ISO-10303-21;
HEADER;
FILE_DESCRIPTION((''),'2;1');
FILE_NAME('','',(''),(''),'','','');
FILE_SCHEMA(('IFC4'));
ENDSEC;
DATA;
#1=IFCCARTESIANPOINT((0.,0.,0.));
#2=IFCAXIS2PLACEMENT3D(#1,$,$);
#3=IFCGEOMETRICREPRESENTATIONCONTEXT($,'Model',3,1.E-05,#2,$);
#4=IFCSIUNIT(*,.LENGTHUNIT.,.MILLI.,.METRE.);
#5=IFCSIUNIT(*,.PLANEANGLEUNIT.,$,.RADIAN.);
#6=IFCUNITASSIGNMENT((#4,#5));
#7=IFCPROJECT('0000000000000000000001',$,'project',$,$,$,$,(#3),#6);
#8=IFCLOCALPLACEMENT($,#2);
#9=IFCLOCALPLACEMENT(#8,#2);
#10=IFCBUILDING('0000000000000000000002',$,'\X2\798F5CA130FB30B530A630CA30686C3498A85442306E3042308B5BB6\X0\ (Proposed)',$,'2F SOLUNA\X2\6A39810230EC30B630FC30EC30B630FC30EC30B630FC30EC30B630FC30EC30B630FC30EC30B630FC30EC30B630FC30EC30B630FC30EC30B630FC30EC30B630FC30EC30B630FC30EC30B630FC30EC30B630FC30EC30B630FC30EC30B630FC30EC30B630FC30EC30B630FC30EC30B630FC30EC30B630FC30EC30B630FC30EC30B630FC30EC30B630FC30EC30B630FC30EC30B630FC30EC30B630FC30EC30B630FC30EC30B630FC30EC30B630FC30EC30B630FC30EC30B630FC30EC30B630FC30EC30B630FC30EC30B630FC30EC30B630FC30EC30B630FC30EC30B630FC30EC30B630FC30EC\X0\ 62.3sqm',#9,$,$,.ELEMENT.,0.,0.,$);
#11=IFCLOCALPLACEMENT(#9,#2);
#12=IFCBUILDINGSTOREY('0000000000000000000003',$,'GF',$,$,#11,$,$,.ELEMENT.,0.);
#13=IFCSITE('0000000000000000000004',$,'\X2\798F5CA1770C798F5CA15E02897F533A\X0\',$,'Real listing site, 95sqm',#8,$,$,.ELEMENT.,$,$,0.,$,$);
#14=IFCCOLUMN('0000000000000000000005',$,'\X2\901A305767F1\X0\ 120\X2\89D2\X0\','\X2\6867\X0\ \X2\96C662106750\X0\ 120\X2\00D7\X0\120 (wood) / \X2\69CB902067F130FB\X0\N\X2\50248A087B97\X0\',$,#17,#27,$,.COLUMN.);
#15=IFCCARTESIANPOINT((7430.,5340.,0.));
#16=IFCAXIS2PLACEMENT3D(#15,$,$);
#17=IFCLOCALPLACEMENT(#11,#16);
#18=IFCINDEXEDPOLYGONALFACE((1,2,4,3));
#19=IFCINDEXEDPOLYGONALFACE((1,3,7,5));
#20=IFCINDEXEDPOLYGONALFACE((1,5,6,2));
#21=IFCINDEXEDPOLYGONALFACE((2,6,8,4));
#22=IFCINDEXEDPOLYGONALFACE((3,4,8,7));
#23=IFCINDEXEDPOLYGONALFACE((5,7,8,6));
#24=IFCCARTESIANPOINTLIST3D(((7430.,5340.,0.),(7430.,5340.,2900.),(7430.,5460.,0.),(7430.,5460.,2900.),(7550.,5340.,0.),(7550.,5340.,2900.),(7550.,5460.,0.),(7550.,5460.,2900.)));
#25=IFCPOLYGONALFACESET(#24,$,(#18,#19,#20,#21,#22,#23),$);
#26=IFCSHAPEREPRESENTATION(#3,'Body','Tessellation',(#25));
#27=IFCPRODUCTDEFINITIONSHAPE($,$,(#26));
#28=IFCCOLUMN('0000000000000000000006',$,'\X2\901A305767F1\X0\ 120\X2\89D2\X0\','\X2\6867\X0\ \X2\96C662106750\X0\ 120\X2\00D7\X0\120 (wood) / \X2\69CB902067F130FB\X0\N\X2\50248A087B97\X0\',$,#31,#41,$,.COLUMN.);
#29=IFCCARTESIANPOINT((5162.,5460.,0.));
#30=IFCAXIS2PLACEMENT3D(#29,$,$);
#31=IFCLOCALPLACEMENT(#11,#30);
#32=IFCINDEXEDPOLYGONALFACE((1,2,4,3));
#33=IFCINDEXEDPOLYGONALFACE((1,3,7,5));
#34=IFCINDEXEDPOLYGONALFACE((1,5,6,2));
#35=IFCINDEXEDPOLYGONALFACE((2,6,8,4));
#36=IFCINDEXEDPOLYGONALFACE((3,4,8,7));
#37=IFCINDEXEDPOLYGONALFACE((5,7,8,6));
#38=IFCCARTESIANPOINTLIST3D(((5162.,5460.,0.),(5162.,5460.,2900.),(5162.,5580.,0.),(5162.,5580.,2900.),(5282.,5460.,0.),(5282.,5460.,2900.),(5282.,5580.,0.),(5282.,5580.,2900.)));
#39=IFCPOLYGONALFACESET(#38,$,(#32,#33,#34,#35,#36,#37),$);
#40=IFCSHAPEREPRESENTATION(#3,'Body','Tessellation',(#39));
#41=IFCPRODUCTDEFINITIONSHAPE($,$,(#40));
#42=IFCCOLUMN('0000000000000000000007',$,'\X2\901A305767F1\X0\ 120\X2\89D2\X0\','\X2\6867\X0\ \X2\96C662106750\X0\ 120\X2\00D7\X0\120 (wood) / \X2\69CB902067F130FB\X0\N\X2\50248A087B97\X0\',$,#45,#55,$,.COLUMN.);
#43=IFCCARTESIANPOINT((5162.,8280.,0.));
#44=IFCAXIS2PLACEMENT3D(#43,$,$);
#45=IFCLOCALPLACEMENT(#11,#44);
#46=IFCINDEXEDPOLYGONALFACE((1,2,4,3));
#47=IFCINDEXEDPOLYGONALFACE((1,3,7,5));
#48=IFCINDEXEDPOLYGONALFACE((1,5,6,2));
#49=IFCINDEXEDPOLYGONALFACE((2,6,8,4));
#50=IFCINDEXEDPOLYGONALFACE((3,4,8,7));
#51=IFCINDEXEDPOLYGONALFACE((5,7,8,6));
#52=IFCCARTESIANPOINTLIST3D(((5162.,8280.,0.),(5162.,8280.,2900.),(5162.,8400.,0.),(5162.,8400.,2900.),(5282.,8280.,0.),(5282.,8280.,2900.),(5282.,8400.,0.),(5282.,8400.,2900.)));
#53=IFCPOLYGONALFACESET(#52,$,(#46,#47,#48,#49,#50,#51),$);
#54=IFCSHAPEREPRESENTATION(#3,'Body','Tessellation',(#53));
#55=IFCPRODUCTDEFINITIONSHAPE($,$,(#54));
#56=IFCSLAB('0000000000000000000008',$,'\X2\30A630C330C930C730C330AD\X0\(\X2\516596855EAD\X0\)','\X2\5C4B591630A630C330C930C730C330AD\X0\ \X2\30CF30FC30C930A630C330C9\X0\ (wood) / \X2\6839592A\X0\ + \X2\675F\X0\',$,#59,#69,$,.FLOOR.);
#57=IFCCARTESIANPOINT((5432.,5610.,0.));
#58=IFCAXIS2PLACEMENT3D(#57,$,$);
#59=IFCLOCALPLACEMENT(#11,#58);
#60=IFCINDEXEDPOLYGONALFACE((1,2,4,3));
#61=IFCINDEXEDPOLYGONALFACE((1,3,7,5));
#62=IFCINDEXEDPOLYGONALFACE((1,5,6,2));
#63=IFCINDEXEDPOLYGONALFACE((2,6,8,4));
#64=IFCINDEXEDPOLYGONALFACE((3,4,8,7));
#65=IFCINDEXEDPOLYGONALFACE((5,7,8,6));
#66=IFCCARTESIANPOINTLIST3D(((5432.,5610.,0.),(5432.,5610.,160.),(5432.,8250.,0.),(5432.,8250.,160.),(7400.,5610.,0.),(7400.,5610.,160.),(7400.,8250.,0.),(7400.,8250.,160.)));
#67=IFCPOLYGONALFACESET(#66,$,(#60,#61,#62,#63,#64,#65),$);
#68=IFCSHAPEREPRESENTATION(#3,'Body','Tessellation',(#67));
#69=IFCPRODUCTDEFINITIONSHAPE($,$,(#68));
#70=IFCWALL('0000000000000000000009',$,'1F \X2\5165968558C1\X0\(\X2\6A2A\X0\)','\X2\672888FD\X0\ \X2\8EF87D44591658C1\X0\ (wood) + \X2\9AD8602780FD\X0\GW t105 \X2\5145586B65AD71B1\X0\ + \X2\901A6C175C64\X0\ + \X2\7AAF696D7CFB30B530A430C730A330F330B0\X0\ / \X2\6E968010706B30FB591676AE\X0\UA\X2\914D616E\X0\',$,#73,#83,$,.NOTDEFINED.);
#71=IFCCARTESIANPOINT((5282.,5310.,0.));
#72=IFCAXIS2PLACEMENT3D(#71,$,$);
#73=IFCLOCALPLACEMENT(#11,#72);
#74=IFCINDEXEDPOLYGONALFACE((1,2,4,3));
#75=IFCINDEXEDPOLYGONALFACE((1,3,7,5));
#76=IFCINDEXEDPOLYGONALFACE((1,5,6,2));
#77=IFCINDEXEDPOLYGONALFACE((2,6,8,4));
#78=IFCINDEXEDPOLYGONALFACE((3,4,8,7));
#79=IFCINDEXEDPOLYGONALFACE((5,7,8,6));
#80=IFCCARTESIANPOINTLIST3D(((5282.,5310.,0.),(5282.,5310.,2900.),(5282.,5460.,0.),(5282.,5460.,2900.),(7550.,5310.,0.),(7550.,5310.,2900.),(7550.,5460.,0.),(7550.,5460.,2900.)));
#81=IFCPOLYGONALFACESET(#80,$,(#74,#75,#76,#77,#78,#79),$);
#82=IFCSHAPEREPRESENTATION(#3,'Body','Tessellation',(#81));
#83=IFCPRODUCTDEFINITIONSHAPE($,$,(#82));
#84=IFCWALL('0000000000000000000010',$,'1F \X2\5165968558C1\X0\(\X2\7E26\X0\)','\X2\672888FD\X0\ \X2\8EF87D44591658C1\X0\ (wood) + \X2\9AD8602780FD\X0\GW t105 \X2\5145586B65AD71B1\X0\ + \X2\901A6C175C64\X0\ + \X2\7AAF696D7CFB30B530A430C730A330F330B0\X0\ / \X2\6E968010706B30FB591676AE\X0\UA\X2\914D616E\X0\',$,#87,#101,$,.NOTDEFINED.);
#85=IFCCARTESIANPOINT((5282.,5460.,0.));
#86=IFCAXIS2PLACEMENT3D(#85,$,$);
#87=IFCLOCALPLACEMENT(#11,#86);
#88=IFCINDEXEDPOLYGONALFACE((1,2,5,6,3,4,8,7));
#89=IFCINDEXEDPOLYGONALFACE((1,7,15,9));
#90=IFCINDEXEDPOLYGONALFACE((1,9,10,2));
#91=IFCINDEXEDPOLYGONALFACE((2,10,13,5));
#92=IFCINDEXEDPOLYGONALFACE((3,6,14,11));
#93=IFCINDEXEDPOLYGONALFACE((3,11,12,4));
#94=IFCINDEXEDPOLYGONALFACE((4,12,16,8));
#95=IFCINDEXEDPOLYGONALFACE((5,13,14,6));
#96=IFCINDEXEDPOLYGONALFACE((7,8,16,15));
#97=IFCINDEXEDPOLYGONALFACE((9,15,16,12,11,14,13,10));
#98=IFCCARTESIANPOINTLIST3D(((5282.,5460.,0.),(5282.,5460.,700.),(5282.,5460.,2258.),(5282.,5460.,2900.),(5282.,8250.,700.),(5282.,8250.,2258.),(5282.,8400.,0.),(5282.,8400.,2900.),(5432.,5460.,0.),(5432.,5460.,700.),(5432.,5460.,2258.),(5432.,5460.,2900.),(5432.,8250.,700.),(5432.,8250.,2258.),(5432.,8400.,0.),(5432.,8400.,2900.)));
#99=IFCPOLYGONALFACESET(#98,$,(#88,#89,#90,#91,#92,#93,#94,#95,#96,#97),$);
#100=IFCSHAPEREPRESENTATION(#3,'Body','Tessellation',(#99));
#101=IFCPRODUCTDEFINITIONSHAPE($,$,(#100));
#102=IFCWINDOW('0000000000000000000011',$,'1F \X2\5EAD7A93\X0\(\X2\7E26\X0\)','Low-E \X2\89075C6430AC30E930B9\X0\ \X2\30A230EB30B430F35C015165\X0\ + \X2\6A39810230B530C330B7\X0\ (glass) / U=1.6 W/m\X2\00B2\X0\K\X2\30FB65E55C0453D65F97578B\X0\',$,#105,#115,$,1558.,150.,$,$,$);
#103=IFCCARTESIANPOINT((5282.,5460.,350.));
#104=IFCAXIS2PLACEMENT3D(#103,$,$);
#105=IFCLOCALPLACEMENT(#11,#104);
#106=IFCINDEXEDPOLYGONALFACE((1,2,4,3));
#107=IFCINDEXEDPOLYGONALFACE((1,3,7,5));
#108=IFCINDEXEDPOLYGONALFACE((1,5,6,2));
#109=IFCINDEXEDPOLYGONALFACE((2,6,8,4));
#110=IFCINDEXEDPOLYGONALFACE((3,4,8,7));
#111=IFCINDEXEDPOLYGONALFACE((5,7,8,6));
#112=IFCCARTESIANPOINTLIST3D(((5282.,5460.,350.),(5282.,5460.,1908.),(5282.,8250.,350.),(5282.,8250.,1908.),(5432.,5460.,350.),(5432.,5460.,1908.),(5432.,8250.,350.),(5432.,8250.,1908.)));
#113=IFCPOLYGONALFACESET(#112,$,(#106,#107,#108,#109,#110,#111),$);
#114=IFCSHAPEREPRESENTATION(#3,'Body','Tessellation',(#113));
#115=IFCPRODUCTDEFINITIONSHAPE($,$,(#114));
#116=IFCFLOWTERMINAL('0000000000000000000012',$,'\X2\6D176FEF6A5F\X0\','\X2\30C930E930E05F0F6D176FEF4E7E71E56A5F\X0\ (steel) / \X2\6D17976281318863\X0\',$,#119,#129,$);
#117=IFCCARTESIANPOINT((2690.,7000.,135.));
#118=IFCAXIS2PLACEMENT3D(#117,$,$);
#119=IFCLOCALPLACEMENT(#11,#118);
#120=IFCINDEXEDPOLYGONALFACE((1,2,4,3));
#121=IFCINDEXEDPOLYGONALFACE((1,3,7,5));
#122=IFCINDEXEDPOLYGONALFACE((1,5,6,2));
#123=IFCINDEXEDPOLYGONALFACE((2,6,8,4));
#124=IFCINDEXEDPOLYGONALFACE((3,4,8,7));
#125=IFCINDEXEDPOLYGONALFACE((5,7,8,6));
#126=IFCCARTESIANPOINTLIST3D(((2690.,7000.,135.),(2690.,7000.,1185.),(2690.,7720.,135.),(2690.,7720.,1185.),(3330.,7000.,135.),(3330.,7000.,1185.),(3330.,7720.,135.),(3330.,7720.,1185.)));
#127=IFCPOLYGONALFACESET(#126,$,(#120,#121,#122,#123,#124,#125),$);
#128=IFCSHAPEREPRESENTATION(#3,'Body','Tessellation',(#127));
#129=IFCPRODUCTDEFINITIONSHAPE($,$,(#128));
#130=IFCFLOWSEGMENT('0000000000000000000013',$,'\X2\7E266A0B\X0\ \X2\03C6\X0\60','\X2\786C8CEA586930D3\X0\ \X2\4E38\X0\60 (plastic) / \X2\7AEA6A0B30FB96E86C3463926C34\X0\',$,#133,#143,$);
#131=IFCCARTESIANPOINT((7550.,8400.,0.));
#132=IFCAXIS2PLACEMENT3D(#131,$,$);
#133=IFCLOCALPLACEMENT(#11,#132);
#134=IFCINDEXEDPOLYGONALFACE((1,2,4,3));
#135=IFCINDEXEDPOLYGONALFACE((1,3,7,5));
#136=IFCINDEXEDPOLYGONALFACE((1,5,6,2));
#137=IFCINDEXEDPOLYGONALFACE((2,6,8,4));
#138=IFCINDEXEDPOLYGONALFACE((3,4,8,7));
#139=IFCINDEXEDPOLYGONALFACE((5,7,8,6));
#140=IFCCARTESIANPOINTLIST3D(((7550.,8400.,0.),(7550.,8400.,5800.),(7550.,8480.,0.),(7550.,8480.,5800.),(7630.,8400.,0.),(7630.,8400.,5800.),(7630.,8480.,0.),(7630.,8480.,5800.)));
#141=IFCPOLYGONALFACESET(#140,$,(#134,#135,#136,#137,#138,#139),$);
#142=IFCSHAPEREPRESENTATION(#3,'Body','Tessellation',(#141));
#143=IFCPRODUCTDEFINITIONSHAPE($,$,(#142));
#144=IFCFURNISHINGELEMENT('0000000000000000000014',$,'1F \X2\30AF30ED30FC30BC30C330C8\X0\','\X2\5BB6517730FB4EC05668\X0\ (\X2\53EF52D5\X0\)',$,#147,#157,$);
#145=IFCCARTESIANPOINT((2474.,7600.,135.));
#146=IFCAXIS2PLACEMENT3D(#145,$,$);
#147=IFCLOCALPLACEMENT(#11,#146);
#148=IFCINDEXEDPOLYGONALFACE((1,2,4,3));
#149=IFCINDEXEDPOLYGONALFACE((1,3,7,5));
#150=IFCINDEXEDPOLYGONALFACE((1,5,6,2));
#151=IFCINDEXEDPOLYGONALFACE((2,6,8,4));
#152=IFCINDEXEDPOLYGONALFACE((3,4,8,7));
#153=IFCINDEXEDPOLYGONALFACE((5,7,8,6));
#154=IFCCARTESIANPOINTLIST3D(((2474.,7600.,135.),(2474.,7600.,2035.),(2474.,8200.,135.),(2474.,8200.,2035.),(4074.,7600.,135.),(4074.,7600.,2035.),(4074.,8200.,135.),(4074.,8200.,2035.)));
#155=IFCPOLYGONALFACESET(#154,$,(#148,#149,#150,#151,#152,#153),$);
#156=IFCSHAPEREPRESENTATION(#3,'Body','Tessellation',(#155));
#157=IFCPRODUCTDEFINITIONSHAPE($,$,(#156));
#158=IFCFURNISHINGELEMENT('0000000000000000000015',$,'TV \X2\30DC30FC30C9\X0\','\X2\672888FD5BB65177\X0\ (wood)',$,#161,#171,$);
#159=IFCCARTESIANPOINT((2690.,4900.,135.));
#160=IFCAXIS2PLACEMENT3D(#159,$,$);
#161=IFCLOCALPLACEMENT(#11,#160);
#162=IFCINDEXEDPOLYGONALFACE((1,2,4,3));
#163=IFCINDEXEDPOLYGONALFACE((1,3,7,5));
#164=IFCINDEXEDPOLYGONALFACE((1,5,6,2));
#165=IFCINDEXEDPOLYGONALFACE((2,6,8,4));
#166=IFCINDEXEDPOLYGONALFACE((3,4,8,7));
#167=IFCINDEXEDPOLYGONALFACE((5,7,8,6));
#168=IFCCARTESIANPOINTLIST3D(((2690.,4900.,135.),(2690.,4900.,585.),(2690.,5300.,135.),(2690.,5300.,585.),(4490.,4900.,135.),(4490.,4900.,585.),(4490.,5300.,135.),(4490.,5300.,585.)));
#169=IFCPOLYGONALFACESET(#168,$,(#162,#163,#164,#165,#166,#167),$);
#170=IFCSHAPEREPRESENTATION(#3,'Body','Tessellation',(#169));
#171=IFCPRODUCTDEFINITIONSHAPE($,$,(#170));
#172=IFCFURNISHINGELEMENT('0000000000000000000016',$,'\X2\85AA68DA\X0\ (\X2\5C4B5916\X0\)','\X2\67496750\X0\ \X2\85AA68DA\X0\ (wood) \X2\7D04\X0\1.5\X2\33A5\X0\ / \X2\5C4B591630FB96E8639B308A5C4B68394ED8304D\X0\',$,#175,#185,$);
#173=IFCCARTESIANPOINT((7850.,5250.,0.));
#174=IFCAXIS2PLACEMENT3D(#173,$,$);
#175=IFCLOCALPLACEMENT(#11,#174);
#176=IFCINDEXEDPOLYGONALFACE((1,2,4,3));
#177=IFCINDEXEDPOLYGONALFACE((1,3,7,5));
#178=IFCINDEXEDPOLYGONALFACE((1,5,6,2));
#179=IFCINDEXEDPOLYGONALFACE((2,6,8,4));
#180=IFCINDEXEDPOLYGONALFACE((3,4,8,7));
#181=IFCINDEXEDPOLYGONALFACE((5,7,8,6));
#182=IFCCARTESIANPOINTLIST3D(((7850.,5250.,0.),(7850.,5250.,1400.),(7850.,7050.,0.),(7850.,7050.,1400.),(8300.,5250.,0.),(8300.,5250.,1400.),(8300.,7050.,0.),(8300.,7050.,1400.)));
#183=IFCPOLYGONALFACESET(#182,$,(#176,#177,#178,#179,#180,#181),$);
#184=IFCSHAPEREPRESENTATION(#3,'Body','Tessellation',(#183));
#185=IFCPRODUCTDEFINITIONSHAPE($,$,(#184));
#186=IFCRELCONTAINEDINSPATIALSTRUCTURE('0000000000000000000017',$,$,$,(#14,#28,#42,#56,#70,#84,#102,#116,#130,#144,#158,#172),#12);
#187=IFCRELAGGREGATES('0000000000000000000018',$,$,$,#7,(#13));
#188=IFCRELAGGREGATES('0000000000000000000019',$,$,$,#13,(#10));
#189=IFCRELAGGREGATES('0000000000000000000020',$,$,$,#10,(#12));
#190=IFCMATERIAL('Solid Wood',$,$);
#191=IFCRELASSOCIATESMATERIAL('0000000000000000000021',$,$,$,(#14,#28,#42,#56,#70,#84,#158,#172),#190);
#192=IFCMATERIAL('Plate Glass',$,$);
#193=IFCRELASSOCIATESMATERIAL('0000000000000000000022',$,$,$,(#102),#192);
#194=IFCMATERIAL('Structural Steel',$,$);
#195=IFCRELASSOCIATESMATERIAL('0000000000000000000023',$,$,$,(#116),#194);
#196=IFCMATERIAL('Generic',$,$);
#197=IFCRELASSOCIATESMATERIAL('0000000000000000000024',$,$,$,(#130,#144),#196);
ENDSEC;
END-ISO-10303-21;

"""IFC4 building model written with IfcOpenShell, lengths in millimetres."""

from ifc_helpers import new_model, si_unit, frame, frame_2d, origin, place, context, project, spatial, rectangle, extrude, material, element, fill, save


model = new_model("IFC4")

# Units and contexts
model_context = context("Model", 3, precision=1e-05, world=origin())
ifc_project = project(units=[si_unit("LENGTHUNIT", "METRE", prefix="MILLI"), si_unit("PLANEANGLEUNIT", "RADIAN")], contexts=[model_context])

# Site, building, storey
site_placement = place(None, origin())
site = spatial("IfcSite", under=ifc_project, at=site_placement, Name="福岡県福岡市西区", ObjectType="Real listing site, 95sqm", CompositionType="ELEMENT", RefElevation=0.0)
building_placement = place(site_placement, origin())
building = spatial("IfcBuilding", under=site, at=building_placement, Name="福岡・サウナと水風呂のある家 (Proposed)", ObjectType="2F SOLUNA樹脂レザーレザーレザーレザーレザーレザーレザーレザーレザーレザーレザーレザーレザーレザーレザーレザーレザーレザーレザーレザーレザーレザーレザーレザーレザーレザーレザーレザーレザーレザーレザーレザーレザーレザーレザーレザーレザーレ 62.3sqm", CompositionType="ELEMENT", ElevationOfRefHeight=0.0, ElevationOfTerrain=0.0)
storey_placement = place(building_placement, origin())
storey = spatial("IfcBuildingStorey", under=building, at=storey_placement, Name="GF", CompositionType="ELEMENT", Elevation=0.0)

# Columns
ifc_material_1 = material(Name="Solid Wood")
column_1_placement = place(storey_placement, frame((7430.0, 5340.0, 0.0)))
element("IfcColumn", 1, at=column_1_placement, inside=storey, material=ifc_material_1, Name="通し柱 120角", Description="桧 集成材 120×120 (wood) / 構造柱・N値計算", PredefinedType="COLUMN", context=model_context, shape_type="SweptSolid", body=[
    extrude(rectangle(XDim=120.0, YDim=120.0, at=frame_2d((60.0, 60.0))), frame((7430.0, 5340.0, 0.0)), (0.0, 0.0, 1.0), 2900.0),
])
column_2_placement = place(storey_placement, frame((5162.0, 5460.0, 0.0)))
element("IfcColumn", 2, at=column_2_placement, inside=storey, material=ifc_material_1, Name="通し柱 120角", Description="桧 集成材 120×120 (wood) / 構造柱・N値計算", PredefinedType="COLUMN", context=model_context, shape_type="SweptSolid", body=[
    extrude(rectangle(XDim=120.0, YDim=120.0, at=frame_2d((60.0, 60.0))), frame((5162.0, 5460.0, 0.0)), (0.0, 0.0, 1.0), 2900.0),
])
column_3_placement = place(storey_placement, frame((5162.0, 8280.0, 0.0)))
element("IfcColumn", 3, at=column_3_placement, inside=storey, material=ifc_material_1, Name="通し柱 120角", Description="桧 集成材 120×120 (wood) / 構造柱・N値計算", PredefinedType="COLUMN", context=model_context, shape_type="SweptSolid", body=[
    extrude(rectangle(XDim=120.0, YDim=120.0, at=frame_2d((60.0, 60.0))), frame((5162.0, 8280.0, 0.0)), (0.0, 0.0, 1.0), 2900.0),
])

# Slab
slab_placement = place(storey_placement, frame((5432.0, 5610.0, 0.0)))
element("IfcSlab", 4, at=slab_placement, inside=storey, material=ifc_material_1, Name="ウッドデッキ(入隅庭)", Description="屋外ウッドデッキ ハードウッド (wood) / 根太 + 束", PredefinedType="FLOOR", context=model_context, shape_type="SweptSolid", body=[
    extrude(rectangle(XDim=1968.0, YDim=2640.0, at=frame_2d((984.0, 1320.0))), frame((5432.0, 5610.0, 0.0)), (0.0, 0.0, 1.0), 160.0),
])

# Wall
wall_1_placement = place(storey_placement, frame((5282.0, 5310.0, 0.0)))
element("IfcWall", 5, at=wall_1_placement, inside=storey, material=ifc_material_1, Name="1F 入隅壁(横)", Description="木製 軸組外壁 (wood) + 高性能GW t105 充填断熱 + 通気層 + 窯業系サイディング / 準耐火・外皮UA配慮", PredefinedType="NOTDEFINED", context=model_context, shape_type="SweptSolid", body=[
    extrude(rectangle(XDim=2268.0, YDim=150.0, at=frame_2d((1134.0, 75.0))), frame((5282.0, 5310.0, 0.0)), (0.0, 0.0, 1.0), 2900.0),
])

# Wall, opening, window
wall_2_placement = place(storey_placement, frame((5282.0, 5460.0, 0.0)))
wall_2 = element("IfcWall", 6, at=wall_2_placement, inside=storey, material=ifc_material_1, Name="1F 入隅壁(縦)", Description="木製 軸組外壁 (wood) + 高性能GW t105 充填断熱 + 通気層 + 窯業系サイディング / 準耐火・外皮UA配慮", PredefinedType="NOTDEFINED", context=model_context, shape_type="SweptSolid", body=[
    extrude(rectangle(XDim=150.0, YDim=2940.0, at=frame_2d((75.0, 1470.0))), frame((5282.0, 5460.0, 0.0)), (0.0, 0.0, 1.0), 2900.0),
])
opening_placement = place(storey_placement, frame((5282.0, 5460.0, 350.0)))
opening = element("IfcOpeningElement", 7, at=opening_placement, cuts=wall_2, PredefinedType="NOTDEFINED", context=model_context, shape_type="SweptSolid", body=[
    extrude(rectangle(XDim=150.0, YDim=2790.0, at=frame_2d((75.0, 1395.0))), frame((5282.0, 5460.0, 350.0)), (0.0, 0.0, 1.0), 1558.0),
])
ifc_material_2 = material(Name="Plate Glass")
window_placement = place(storey_placement, frame((5282.0, 5460.0, 350.0)))
window = element("IfcWindow", 8, at=window_placement, inside=storey, material=ifc_material_2, Name="1F 庭窓(縦)", Description="Low-E 複層ガラス アルゴン封入 + 樹脂サッシ (glass) / U=1.6 W/m²K・日射取得型", OverallHeight=1558.0, OverallWidth=150.0, context=model_context, shape_type="SweptSolid", body=[
    extrude(rectangle(XDim=150.0, YDim=2790.0, at=frame_2d((75.0, 1395.0))), frame((5282.0, 5460.0, 350.0)), (0.0, 0.0, 1.0), 1558.0),
])
fill(opening, window)

# Flow terminal
ifc_material_3 = material(Name="Structural Steel")
flow_terminal_placement = place(storey_placement, frame((2690.0, 7000.0, 135.0)))
element("IfcFlowTerminal", 9, at=flow_terminal_placement, inside=storey, material=ifc_material_3, Name="洗濯機", Description="ドラム式洗濯乾燥機 (steel) / 洗面脱衣", context=model_context, shape_type="SweptSolid", body=[
    extrude(rectangle(XDim=640.0, YDim=720.0, at=frame_2d((320.0, 360.0))), frame((2690.0, 7000.0, 135.0)), (0.0, 0.0, 1.0), 1050.0),
])

# Flow segment
ifc_material_4 = material(Name="Generic")
flow_segment_placement = place(storey_placement, frame((7550.0, 8400.0, 0.0)))
element("IfcFlowSegment", 10, at=flow_segment_placement, inside=storey, material=ifc_material_4, Name="縦樋 φ60", Description="硬質塩ビ 丸60 (plastic) / 竪樋・雨水排水", context=model_context, shape_type="SweptSolid", body=[
    extrude(rectangle(XDim=80.0, YDim=80.0, at=frame_2d((40.0, 40.0))), frame((7550.0, 8400.0, 0.0)), (0.0, 0.0, 1.0), 5800.0),
])

# Furnishing elements
furnishing_1_placement = place(storey_placement, frame((2474.0, 7600.0, 135.0)))
element("IfcFurnishingElement", 11, at=furnishing_1_placement, inside=storey, material=ifc_material_4, Name="1F クローゼット", Description="家具・什器 (可動)", context=model_context, shape_type="SweptSolid", body=[
    extrude(rectangle(XDim=1600.0, YDim=600.0, at=frame_2d((800.0, 300.0))), frame((2474.0, 7600.0, 135.0)), (0.0, 0.0, 1.0), 1900.0),
])
furnishing_2_placement = place(storey_placement, frame((2690.0, 4900.0, 135.0)))
element("IfcFurnishingElement", 12, at=furnishing_2_placement, inside=storey, material=ifc_material_1, Name="TV ボード", Description="木製家具 (wood)", context=model_context, shape_type="SweptSolid", body=[
    extrude(rectangle(XDim=1800.0, YDim=400.0, at=frame_2d((900.0, 200.0))), frame((2690.0, 4900.0, 135.0)), (0.0, 0.0, 1.0), 450.0),
])
furnishing_3_placement = place(storey_placement, frame((7850.0, 5250.0, 0.0)))
element("IfcFurnishingElement", 13, at=furnishing_3_placement, inside=storey, material=ifc_material_1, Name="薪棚 (屋外)", Description="杉材 薪棚 (wood) 約1.5㎥ / 屋外・雨掛り屋根付き", context=model_context, shape_type="SweptSolid", body=[
    extrude(rectangle(XDim=450.0, YDim=1800.0, at=frame_2d((225.0, 900.0))), frame((7850.0, 5250.0, 0.0)), (0.0, 0.0, 1.0), 1400.0),
])

save(model, "model.ifc")
